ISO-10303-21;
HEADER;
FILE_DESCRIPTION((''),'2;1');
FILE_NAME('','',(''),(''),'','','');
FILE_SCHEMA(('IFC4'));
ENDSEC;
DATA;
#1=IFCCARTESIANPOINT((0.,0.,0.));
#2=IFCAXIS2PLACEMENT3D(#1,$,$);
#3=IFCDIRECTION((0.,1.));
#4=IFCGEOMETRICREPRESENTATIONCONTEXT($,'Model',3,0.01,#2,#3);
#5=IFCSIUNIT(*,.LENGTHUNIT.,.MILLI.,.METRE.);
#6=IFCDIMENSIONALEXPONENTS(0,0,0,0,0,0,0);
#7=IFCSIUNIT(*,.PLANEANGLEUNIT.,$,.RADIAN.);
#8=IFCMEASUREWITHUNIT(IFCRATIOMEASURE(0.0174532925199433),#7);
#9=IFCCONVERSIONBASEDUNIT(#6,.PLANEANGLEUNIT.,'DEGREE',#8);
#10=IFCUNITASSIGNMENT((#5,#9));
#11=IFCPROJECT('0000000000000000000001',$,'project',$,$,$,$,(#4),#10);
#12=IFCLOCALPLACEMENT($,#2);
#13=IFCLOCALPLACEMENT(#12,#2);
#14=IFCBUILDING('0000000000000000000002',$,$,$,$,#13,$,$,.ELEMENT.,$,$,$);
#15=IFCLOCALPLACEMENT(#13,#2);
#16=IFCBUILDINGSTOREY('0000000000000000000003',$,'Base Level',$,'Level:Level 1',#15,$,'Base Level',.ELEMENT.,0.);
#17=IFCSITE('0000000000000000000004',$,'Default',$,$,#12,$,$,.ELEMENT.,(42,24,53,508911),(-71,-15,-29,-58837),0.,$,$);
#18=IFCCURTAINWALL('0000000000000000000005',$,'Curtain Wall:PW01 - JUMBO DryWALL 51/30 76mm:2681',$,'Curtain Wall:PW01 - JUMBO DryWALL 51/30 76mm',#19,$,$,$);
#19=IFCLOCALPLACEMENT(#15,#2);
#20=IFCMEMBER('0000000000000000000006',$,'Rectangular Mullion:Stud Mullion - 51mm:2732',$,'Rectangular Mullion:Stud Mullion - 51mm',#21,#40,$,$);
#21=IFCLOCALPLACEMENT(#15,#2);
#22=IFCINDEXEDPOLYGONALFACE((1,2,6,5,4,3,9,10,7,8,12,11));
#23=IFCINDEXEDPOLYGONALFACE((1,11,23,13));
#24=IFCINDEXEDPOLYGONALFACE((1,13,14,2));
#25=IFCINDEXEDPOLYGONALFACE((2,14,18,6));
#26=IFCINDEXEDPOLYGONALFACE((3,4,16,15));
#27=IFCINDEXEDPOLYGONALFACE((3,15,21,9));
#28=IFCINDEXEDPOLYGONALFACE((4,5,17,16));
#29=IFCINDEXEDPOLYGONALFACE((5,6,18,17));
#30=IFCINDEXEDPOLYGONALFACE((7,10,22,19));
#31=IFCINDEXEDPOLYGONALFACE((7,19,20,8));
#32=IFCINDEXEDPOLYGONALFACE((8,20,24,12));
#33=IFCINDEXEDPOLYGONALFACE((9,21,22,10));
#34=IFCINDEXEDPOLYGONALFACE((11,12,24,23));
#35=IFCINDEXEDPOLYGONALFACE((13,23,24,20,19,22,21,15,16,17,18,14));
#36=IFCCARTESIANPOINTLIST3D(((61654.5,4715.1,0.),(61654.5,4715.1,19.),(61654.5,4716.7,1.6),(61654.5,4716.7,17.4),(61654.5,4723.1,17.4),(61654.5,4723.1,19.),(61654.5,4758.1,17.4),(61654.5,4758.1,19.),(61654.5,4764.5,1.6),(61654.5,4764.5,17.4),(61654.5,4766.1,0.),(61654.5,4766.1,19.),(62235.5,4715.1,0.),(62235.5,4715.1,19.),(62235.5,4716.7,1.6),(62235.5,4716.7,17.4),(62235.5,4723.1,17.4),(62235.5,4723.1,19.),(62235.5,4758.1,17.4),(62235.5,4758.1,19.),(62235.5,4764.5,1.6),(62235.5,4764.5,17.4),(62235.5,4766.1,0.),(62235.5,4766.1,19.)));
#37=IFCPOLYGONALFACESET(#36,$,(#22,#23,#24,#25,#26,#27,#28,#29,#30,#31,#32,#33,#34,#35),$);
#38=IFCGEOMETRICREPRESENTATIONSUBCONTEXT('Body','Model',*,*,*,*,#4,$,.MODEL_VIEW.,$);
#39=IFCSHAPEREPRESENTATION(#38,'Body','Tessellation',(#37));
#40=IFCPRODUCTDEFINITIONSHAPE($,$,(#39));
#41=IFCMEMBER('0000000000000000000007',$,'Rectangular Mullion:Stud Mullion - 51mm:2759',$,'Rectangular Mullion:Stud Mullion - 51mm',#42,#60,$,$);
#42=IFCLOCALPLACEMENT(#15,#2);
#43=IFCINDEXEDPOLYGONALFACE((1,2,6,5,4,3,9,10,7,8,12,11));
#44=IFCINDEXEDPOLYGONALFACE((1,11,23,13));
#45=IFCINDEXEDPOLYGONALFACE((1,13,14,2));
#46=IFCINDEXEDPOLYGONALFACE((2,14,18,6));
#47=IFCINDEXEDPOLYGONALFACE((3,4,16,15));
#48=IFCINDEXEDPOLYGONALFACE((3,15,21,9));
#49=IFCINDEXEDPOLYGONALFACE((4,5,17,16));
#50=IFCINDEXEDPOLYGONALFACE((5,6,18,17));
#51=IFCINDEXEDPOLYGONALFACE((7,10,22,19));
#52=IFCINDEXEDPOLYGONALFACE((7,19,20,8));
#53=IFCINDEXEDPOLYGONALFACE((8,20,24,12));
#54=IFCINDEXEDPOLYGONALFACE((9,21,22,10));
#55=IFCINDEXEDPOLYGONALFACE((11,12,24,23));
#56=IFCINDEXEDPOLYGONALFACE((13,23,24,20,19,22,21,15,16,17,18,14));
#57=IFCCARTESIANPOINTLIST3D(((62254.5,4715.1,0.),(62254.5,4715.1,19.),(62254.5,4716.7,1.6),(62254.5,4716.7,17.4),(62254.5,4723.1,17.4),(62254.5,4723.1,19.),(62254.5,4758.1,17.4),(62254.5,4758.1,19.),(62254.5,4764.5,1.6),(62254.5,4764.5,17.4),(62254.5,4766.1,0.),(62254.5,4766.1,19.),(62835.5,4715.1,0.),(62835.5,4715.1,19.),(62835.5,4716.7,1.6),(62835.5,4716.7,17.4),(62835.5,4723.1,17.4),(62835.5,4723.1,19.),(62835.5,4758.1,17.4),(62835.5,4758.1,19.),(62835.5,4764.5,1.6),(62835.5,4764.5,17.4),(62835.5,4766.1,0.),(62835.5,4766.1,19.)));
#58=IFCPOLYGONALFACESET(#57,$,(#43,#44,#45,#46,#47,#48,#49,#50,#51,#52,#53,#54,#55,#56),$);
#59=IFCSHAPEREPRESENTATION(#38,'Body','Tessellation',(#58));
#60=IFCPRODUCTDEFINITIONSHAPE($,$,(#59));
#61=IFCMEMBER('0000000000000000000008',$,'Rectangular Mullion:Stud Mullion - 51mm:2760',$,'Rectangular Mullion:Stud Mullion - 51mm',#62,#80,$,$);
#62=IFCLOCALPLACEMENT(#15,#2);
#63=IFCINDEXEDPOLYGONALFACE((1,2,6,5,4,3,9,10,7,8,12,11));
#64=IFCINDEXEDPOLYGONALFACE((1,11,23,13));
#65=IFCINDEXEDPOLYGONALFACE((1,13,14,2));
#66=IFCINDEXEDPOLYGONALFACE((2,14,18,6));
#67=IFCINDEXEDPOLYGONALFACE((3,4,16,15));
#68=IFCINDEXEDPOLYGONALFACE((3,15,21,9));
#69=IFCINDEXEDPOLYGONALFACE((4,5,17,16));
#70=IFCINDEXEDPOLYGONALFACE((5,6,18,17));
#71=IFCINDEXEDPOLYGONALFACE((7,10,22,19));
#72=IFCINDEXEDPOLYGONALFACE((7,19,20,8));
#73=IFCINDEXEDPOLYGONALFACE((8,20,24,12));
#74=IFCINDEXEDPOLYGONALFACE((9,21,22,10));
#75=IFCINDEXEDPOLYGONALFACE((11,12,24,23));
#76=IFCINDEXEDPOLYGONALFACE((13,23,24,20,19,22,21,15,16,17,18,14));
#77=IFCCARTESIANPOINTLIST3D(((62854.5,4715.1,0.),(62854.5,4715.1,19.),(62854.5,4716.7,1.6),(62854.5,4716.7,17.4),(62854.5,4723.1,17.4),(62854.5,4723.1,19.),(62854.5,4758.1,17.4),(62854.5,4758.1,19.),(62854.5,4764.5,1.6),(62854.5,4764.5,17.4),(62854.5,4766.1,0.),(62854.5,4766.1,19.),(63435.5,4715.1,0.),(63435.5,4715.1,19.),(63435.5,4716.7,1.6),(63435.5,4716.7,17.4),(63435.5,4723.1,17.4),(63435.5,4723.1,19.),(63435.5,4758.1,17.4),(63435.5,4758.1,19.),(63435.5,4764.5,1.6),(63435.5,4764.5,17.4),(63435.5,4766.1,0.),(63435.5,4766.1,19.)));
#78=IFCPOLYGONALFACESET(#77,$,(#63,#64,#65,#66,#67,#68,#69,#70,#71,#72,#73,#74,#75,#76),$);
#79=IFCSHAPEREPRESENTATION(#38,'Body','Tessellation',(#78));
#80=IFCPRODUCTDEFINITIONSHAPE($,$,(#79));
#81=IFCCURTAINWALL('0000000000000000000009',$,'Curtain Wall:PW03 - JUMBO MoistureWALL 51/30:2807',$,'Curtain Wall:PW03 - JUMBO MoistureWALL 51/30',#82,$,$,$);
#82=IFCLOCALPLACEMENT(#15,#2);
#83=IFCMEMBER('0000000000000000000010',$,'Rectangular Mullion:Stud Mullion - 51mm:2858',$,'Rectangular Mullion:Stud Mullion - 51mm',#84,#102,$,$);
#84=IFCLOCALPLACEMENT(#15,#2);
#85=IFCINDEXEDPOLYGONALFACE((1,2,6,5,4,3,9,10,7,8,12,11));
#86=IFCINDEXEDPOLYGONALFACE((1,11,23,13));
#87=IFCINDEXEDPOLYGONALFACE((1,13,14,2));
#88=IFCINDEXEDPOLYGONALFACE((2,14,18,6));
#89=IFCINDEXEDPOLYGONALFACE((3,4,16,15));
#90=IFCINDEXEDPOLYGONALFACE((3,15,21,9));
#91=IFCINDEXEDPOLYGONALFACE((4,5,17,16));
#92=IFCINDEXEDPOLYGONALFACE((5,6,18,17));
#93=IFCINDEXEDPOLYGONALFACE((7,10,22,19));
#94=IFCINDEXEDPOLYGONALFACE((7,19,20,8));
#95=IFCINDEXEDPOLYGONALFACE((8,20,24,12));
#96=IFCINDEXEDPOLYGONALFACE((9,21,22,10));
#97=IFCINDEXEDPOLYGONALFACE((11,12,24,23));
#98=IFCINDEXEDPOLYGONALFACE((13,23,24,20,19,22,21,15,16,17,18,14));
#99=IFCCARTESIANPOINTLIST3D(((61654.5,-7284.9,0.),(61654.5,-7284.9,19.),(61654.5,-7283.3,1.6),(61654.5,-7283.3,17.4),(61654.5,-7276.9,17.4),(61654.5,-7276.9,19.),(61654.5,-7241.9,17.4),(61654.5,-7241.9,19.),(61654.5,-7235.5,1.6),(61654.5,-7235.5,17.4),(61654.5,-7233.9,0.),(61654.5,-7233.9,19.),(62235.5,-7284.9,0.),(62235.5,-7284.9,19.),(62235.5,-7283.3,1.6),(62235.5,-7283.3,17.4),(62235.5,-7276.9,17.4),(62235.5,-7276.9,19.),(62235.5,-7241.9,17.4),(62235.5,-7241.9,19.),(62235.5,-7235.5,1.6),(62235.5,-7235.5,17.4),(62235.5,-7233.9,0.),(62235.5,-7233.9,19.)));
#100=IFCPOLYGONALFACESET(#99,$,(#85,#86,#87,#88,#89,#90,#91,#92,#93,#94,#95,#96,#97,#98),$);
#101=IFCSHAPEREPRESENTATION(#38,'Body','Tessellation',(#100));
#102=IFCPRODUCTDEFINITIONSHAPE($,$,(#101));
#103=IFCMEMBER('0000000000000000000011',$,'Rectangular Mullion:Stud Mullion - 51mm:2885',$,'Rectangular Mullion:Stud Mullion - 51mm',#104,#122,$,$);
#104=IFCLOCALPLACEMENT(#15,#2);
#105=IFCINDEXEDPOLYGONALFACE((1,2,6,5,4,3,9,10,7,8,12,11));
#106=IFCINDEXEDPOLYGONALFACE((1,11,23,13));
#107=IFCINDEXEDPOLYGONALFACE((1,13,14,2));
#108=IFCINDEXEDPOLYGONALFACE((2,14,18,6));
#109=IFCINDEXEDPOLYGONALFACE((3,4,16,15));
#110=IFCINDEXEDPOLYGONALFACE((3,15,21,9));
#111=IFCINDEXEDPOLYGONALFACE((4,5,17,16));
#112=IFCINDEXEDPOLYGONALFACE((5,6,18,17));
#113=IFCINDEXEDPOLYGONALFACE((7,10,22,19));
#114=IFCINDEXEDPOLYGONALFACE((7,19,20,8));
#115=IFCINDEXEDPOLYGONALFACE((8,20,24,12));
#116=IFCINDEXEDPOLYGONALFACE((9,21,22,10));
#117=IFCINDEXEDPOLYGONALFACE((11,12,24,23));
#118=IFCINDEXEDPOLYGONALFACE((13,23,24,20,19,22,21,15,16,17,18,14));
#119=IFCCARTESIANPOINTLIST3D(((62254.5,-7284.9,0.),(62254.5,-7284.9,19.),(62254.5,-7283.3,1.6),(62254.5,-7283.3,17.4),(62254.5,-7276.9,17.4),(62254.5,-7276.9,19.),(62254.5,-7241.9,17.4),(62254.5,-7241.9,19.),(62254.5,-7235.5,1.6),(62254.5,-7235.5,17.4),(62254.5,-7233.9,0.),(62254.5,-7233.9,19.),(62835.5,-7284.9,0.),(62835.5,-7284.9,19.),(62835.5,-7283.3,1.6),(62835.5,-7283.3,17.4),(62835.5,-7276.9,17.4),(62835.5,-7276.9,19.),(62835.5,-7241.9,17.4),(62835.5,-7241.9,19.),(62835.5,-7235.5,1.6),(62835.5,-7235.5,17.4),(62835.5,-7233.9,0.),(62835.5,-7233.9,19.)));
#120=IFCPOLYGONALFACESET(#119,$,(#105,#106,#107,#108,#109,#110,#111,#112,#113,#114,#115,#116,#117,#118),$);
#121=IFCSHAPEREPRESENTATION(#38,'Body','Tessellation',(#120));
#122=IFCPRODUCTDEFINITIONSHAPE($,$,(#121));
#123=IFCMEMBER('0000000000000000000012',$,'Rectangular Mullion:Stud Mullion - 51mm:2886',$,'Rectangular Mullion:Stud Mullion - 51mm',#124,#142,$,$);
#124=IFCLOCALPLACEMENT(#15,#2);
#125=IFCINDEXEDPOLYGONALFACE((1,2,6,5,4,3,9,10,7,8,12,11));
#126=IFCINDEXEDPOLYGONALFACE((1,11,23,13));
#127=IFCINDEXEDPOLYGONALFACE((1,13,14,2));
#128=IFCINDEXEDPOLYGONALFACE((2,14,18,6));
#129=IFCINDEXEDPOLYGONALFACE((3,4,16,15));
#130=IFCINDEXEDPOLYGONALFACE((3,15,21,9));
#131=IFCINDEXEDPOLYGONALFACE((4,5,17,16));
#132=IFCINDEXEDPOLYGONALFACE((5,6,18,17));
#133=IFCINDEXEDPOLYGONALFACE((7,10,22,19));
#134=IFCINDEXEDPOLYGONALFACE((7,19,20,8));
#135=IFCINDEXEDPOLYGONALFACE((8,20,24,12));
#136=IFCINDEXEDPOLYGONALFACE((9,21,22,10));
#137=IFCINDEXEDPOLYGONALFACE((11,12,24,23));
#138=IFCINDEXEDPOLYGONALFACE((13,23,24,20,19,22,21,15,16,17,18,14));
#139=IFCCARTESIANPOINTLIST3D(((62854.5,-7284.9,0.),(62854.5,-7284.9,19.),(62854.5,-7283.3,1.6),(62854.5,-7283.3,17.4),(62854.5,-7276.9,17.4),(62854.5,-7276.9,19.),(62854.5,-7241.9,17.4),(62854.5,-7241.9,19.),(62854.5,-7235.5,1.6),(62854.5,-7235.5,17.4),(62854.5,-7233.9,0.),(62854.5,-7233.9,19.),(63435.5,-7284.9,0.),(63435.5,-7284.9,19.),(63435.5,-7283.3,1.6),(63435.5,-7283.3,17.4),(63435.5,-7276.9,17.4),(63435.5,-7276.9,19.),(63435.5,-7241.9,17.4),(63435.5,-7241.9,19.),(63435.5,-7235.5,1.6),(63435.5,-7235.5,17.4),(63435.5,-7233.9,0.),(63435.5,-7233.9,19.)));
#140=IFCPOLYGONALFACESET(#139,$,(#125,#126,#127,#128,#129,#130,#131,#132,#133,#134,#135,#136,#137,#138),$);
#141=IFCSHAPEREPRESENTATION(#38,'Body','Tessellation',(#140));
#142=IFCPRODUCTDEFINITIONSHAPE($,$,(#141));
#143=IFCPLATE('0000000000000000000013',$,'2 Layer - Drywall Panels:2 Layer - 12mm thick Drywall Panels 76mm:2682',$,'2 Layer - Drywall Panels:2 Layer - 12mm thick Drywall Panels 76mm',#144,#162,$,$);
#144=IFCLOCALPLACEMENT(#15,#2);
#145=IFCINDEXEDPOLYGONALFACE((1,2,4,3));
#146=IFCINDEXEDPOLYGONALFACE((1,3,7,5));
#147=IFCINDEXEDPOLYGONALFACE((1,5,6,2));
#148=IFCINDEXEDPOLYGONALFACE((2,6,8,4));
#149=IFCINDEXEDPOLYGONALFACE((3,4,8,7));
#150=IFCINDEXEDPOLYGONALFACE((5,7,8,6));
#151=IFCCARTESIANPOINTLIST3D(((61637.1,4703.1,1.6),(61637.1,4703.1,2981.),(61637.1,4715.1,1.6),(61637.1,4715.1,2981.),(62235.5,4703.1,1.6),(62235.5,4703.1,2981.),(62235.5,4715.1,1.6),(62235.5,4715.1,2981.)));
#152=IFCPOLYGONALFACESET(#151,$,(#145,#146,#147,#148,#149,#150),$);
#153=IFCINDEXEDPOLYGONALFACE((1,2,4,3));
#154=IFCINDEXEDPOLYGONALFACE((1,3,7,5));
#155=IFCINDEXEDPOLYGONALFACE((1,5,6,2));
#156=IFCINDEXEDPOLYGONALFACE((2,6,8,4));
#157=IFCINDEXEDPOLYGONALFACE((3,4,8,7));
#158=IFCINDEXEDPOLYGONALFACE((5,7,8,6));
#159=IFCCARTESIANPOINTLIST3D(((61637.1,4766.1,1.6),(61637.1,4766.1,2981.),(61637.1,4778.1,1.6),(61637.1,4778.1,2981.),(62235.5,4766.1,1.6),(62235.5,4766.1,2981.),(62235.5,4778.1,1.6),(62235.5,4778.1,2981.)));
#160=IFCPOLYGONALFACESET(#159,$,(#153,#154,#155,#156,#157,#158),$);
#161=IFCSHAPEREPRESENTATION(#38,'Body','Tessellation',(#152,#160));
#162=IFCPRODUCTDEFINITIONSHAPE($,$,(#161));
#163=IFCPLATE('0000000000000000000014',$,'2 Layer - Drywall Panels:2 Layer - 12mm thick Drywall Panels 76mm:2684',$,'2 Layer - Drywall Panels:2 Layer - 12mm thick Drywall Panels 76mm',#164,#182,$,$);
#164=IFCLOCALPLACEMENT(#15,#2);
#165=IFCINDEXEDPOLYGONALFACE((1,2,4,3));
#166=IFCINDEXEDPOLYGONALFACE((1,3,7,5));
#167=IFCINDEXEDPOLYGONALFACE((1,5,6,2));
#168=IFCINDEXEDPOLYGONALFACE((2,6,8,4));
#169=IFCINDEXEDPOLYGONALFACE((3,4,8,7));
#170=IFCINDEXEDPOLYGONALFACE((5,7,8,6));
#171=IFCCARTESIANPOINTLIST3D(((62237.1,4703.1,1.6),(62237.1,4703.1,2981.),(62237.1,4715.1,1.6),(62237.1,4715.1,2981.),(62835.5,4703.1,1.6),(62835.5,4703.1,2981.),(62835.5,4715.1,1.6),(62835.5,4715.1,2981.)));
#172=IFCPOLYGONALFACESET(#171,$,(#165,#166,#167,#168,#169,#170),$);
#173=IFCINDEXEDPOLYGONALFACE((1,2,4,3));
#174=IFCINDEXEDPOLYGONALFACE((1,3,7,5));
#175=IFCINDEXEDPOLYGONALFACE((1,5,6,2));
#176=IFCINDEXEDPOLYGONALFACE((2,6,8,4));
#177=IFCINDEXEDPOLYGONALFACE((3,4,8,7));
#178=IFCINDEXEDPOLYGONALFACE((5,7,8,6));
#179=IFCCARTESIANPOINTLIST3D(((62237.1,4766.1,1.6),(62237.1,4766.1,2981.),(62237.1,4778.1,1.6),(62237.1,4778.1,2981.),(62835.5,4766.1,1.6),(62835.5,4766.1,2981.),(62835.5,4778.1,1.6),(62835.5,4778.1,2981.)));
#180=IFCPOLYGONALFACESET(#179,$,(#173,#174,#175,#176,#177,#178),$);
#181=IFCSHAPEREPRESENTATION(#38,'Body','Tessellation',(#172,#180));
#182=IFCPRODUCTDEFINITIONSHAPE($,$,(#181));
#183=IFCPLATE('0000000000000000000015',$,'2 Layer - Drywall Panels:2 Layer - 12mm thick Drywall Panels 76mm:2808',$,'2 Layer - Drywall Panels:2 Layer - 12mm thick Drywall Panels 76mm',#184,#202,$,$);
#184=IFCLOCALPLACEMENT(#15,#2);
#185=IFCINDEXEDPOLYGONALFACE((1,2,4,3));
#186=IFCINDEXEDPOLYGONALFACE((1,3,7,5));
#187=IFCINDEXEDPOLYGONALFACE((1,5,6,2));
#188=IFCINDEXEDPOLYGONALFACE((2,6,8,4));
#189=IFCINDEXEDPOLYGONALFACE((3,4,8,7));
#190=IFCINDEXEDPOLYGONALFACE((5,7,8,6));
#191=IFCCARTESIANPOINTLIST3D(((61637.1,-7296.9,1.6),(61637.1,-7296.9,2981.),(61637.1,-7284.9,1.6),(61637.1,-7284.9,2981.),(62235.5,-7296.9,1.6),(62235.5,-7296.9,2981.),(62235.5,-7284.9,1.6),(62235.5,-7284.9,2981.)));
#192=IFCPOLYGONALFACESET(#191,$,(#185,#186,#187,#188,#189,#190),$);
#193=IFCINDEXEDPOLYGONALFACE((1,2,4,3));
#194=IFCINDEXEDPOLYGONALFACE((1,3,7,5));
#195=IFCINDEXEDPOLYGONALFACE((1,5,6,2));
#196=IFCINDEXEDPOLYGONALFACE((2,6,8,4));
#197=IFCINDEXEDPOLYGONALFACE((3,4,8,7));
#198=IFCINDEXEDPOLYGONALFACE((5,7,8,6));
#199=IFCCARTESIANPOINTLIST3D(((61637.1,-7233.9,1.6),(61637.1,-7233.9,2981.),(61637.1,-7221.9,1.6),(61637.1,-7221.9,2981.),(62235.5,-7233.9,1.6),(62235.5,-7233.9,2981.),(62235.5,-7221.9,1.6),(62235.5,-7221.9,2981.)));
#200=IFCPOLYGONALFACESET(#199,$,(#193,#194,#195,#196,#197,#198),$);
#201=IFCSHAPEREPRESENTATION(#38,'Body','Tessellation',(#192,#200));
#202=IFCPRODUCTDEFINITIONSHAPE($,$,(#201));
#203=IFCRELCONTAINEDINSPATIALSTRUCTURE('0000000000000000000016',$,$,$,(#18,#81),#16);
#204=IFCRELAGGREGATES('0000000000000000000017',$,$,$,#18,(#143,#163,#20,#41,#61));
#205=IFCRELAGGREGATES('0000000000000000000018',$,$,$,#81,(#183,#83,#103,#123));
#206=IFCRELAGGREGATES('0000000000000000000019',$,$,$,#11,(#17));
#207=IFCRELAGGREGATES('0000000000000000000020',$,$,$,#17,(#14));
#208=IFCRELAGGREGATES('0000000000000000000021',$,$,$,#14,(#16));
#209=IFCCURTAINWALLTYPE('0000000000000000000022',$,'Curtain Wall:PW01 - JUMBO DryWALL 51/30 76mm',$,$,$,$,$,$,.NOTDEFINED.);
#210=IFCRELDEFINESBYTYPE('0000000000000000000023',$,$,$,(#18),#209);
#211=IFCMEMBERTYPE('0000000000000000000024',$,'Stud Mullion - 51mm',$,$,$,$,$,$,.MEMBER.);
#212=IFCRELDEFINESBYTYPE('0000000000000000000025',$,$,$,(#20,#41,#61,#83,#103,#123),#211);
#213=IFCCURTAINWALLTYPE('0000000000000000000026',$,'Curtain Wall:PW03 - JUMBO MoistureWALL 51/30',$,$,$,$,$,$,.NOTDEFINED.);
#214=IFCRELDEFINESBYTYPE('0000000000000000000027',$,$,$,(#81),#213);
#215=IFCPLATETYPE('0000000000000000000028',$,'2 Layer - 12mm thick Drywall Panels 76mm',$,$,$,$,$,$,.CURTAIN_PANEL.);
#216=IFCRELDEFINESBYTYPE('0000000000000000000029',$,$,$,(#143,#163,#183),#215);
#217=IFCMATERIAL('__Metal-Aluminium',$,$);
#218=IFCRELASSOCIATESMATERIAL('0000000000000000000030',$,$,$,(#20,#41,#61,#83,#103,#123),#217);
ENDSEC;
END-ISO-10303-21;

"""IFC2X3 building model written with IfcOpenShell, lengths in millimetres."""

from ifc_helpers import new_model, entity, si_unit, converted_unit, direction, frame, frame_2d, origin, origin_2d_with_axis, place, context, subcontext, project, spatial, polyline, rectangle, outline, extrude, source, transform, mapped, material, type_object, type_shapes, element, aggregate, save


model = new_model("IFC2X3")

# Units and contexts
model_context = context("Model", 3, precision=0.01, world=origin(), true_north=direction((0.0, 1.0)))
body_context = subcontext(model_context, "Body", "Model", "MODEL_VIEW")
ifc_project = project(units=[si_unit("LENGTHUNIT", "METRE", prefix="MILLI"), converted_unit("PLANEANGLEUNIT", "DEGREE", entity("IfcRatioMeasure", 0.0174532925199433), si_unit("PLANEANGLEUNIT", "RADIAN"), dimensions=[0, 0, 0, 0, 0, 0, 0])], contexts=[model_context])

# Site, building, storey
site_placement = place(None, origin())
site = spatial("IfcSite", under=ifc_project, at=site_placement, Name="Default", CompositionType="ELEMENT", RefLatitude=(42, 24, 53, 508911), RefLongitude=(-71, -15, -29, -58837), RefElevation=0.0)
building_placement = place(site_placement, origin())
building = spatial("IfcBuilding", under=site, at=building_placement, CompositionType="ELEMENT")
storey_placement = place(building_placement, origin())
storey = spatial("IfcBuildingStorey", under=building, at=storey_placement, Name="Base Level", ObjectType="Level:Level 1", LongName="Base Level", CompositionType="ELEMENT", Elevation=0.0)

# Curtain walls, members
curtain_wall_type_1 = type_object("IfcCurtainWallType", Name="Curtain Wall:PW01 - JUMBO DryWALL 51/30 76mm", PredefinedType="NOTDEFINED")
curtain_wall_1_placement = place(building_placement, origin())
curtain_wall_1 = element("IfcCurtainWall", 1, at=curtain_wall_1_placement, inside=storey, type_object=curtain_wall_type_1, Name="Curtain Wall:PW01 - JUMBO DryWALL 51/30 76mm:2681", ObjectType="Curtain Wall:PW01 - JUMBO DryWALL 51/30 76mm")
ifc_material_1 = material(Name="__Metal-Aluminium")
member_type_1 = type_object("IfcMemberType", Name="Stud Mullion - 51mm", PredefinedType="MEMBER")
shared_shape_1 = source(origin(), body_context, "Body", "SweptSolid", [
    extrude(outline(polyline([(17.5, -6.6), (25.5, -6.6), (25.5, 12.4), (-25.5, 12.4), (-25.5, -6.6), (-17.5, -6.6), (-17.5, -5.0), (-23.9, -5.0), (-23.9, 10.8), (23.9, 10.8), (23.9, -5.0), (17.5, -5.0), (17.5, -6.6)])), frame((-12.4, 0.0, -581.0), z_axis=(0.0, 0.0, 1.0), x_axis=(0.0, -1.0, 0.0)), (0.0, 0.0, 1.0), 581.0),
])
type_shapes(member_type_1, [shared_shape_1])
member_1_placement = place(building_placement, frame((61654.5, 4740.6, 0.0), z_axis=(-1.0, 0.0, 0.0), x_axis=(0.0, 0.0, -1.0)))
member_1 = element("IfcMember", 2, at=member_1_placement, type_object=member_type_1, material=ifc_material_1, Name="Rectangular Mullion:Stud Mullion - 51mm:2732", ObjectType="Rectangular Mullion:Stud Mullion - 51mm", context=body_context, shape_type="MappedRepresentation", body=[
    mapped(shared_shape_1, transform((0.0, 0.0, 0.0), scale=1.0)),
])
member_2_placement = place(building_placement, frame((62254.5, 4740.6, 0.0), z_axis=(-1.0, 0.0, 0.0), x_axis=(0.0, 0.0, -1.0)))
member_2 = element("IfcMember", 3, at=member_2_placement, type_object=member_type_1, material=ifc_material_1, Name="Rectangular Mullion:Stud Mullion - 51mm:2759", ObjectType="Rectangular Mullion:Stud Mullion - 51mm", context=body_context, shape_type="MappedRepresentation", body=[
    mapped(shared_shape_1, transform((0.0, 0.0, 0.0), scale=1.0)),
])
member_3_placement = place(building_placement, frame((62854.5, 4740.6, 0.0), z_axis=(-1.0, 0.0, 0.0), x_axis=(0.0, 0.0, -1.0)))
member_3 = element("IfcMember", 4, at=member_3_placement, type_object=member_type_1, material=ifc_material_1, Name="Rectangular Mullion:Stud Mullion - 51mm:2760", ObjectType="Rectangular Mullion:Stud Mullion - 51mm", context=body_context, shape_type="MappedRepresentation", body=[
    mapped(shared_shape_1, transform((0.0, 0.0, 0.0), scale=1.0)),
])
curtain_wall_type_2 = type_object("IfcCurtainWallType", Name="Curtain Wall:PW03 - JUMBO MoistureWALL 51/30", PredefinedType="NOTDEFINED")
curtain_wall_2_placement = place(building_placement, origin())
curtain_wall_2 = element("IfcCurtainWall", 5, at=curtain_wall_2_placement, inside=storey, type_object=curtain_wall_type_2, Name="Curtain Wall:PW03 - JUMBO MoistureWALL 51/30:2807", ObjectType="Curtain Wall:PW03 - JUMBO MoistureWALL 51/30")
member_4_placement = place(building_placement, frame((61654.5, -7259.4, 0.0), z_axis=(-1.0, 0.0, 0.0), x_axis=(0.0, 0.0, -1.0)))
member_4 = element("IfcMember", 6, at=member_4_placement, type_object=member_type_1, material=ifc_material_1, Name="Rectangular Mullion:Stud Mullion - 51mm:2858", ObjectType="Rectangular Mullion:Stud Mullion - 51mm", context=body_context, shape_type="MappedRepresentation", body=[
    mapped(shared_shape_1, transform((0.0, 0.0, 0.0), scale=1.0)),
])
member_5_placement = place(building_placement, frame((62254.5, -7259.4, 0.0), z_axis=(-1.0, 0.0, 0.0), x_axis=(0.0, 0.0, -1.0)))
member_5 = element("IfcMember", 7, at=member_5_placement, type_object=member_type_1, material=ifc_material_1, Name="Rectangular Mullion:Stud Mullion - 51mm:2885", ObjectType="Rectangular Mullion:Stud Mullion - 51mm", context=body_context, shape_type="MappedRepresentation", body=[
    mapped(shared_shape_1, transform((0.0, 0.0, 0.0), scale=1.0)),
])
member_6_placement = place(building_placement, frame((62854.5, -7259.4, 0.0), z_axis=(-1.0, 0.0, 0.0), x_axis=(0.0, 0.0, -1.0)))
member_6 = element("IfcMember", 8, at=member_6_placement, type_object=member_type_1, material=ifc_material_1, Name="Rectangular Mullion:Stud Mullion - 51mm:2886", ObjectType="Rectangular Mullion:Stud Mullion - 51mm", context=body_context, shape_type="MappedRepresentation", body=[
    mapped(shared_shape_1, transform((0.0, 0.0, 0.0), scale=1.0)),
])

# Plates
plate_type = type_object("IfcPlateType", Name="2 Layer - 12mm thick Drywall Panels 76mm", PredefinedType="CURTAIN_PANEL")
shared_shape_2 = source(origin(), body_context, "Body", "SweptSolid", [
    extrude(rectangle(XDim=598.4, YDim=12.0, at=origin_2d_with_axis()), frame((0.0, -31.5, 0.0), z_axis=(0.0, 0.0, 1.0), x_axis=(-1.0, 0.0, 0.0)), (0.0, 0.0, 1.0), 2979.4),
    extrude(rectangle(XDim=12.0, YDim=598.4, at=frame_2d((0.0, 0.0), x_axis=(1.0, 0.0))), frame((0.0, 31.5, 0.0), z_axis=(0.0, 0.0, 1.0), x_axis=(0.0, 1.0, 0.0)), (0.0, 0.0, 1.0), 2979.4),
])
type_shapes(plate_type, [shared_shape_2])
plate_1_placement = place(curtain_wall_1_placement, frame((61936.3, 4740.6, 1.6)))
plate_1 = element("IfcPlate", 9, at=plate_1_placement, type_object=plate_type, Name="2 Layer - Drywall Panels:2 Layer - 12mm thick Drywall Panels 76mm:2682", ObjectType="2 Layer - Drywall Panels:2 Layer - 12mm thick Drywall Panels 76mm", context=body_context, shape_type="MappedRepresentation", body=[
    mapped(shared_shape_2, transform((0.0, 0.0, 0.0), scale=1.0)),
])
plate_2_placement = place(curtain_wall_1_placement, frame((62536.3, 4740.6, 1.6)))
plate_2 = element("IfcPlate", 10, at=plate_2_placement, type_object=plate_type, Name="2 Layer - Drywall Panels:2 Layer - 12mm thick Drywall Panels 76mm:2684", ObjectType="2 Layer - Drywall Panels:2 Layer - 12mm thick Drywall Panels 76mm", context=body_context, shape_type="MappedRepresentation", body=[
    mapped(shared_shape_2, transform((0.0, 0.0, 0.0), scale=1.0)),
])
aggregate(curtain_wall_1, [plate_1, plate_2, member_1, member_2, member_3])
plate_3_placement = place(curtain_wall_2_placement, frame((61936.3, -7259.4, 1.6)))
plate_3 = element("IfcPlate", 11, at=plate_3_placement, type_object=plate_type, Name="2 Layer - Drywall Panels:2 Layer - 12mm thick Drywall Panels 76mm:2808", ObjectType="2 Layer - Drywall Panels:2 Layer - 12mm thick Drywall Panels 76mm", context=body_context, shape_type="MappedRepresentation", body=[
    mapped(shared_shape_2, transform((0.0, 0.0, 0.0), scale=1.0)),
])
aggregate(curtain_wall_2, [plate_3, member_4, member_5, member_6])

save(model, "model.ifc")
